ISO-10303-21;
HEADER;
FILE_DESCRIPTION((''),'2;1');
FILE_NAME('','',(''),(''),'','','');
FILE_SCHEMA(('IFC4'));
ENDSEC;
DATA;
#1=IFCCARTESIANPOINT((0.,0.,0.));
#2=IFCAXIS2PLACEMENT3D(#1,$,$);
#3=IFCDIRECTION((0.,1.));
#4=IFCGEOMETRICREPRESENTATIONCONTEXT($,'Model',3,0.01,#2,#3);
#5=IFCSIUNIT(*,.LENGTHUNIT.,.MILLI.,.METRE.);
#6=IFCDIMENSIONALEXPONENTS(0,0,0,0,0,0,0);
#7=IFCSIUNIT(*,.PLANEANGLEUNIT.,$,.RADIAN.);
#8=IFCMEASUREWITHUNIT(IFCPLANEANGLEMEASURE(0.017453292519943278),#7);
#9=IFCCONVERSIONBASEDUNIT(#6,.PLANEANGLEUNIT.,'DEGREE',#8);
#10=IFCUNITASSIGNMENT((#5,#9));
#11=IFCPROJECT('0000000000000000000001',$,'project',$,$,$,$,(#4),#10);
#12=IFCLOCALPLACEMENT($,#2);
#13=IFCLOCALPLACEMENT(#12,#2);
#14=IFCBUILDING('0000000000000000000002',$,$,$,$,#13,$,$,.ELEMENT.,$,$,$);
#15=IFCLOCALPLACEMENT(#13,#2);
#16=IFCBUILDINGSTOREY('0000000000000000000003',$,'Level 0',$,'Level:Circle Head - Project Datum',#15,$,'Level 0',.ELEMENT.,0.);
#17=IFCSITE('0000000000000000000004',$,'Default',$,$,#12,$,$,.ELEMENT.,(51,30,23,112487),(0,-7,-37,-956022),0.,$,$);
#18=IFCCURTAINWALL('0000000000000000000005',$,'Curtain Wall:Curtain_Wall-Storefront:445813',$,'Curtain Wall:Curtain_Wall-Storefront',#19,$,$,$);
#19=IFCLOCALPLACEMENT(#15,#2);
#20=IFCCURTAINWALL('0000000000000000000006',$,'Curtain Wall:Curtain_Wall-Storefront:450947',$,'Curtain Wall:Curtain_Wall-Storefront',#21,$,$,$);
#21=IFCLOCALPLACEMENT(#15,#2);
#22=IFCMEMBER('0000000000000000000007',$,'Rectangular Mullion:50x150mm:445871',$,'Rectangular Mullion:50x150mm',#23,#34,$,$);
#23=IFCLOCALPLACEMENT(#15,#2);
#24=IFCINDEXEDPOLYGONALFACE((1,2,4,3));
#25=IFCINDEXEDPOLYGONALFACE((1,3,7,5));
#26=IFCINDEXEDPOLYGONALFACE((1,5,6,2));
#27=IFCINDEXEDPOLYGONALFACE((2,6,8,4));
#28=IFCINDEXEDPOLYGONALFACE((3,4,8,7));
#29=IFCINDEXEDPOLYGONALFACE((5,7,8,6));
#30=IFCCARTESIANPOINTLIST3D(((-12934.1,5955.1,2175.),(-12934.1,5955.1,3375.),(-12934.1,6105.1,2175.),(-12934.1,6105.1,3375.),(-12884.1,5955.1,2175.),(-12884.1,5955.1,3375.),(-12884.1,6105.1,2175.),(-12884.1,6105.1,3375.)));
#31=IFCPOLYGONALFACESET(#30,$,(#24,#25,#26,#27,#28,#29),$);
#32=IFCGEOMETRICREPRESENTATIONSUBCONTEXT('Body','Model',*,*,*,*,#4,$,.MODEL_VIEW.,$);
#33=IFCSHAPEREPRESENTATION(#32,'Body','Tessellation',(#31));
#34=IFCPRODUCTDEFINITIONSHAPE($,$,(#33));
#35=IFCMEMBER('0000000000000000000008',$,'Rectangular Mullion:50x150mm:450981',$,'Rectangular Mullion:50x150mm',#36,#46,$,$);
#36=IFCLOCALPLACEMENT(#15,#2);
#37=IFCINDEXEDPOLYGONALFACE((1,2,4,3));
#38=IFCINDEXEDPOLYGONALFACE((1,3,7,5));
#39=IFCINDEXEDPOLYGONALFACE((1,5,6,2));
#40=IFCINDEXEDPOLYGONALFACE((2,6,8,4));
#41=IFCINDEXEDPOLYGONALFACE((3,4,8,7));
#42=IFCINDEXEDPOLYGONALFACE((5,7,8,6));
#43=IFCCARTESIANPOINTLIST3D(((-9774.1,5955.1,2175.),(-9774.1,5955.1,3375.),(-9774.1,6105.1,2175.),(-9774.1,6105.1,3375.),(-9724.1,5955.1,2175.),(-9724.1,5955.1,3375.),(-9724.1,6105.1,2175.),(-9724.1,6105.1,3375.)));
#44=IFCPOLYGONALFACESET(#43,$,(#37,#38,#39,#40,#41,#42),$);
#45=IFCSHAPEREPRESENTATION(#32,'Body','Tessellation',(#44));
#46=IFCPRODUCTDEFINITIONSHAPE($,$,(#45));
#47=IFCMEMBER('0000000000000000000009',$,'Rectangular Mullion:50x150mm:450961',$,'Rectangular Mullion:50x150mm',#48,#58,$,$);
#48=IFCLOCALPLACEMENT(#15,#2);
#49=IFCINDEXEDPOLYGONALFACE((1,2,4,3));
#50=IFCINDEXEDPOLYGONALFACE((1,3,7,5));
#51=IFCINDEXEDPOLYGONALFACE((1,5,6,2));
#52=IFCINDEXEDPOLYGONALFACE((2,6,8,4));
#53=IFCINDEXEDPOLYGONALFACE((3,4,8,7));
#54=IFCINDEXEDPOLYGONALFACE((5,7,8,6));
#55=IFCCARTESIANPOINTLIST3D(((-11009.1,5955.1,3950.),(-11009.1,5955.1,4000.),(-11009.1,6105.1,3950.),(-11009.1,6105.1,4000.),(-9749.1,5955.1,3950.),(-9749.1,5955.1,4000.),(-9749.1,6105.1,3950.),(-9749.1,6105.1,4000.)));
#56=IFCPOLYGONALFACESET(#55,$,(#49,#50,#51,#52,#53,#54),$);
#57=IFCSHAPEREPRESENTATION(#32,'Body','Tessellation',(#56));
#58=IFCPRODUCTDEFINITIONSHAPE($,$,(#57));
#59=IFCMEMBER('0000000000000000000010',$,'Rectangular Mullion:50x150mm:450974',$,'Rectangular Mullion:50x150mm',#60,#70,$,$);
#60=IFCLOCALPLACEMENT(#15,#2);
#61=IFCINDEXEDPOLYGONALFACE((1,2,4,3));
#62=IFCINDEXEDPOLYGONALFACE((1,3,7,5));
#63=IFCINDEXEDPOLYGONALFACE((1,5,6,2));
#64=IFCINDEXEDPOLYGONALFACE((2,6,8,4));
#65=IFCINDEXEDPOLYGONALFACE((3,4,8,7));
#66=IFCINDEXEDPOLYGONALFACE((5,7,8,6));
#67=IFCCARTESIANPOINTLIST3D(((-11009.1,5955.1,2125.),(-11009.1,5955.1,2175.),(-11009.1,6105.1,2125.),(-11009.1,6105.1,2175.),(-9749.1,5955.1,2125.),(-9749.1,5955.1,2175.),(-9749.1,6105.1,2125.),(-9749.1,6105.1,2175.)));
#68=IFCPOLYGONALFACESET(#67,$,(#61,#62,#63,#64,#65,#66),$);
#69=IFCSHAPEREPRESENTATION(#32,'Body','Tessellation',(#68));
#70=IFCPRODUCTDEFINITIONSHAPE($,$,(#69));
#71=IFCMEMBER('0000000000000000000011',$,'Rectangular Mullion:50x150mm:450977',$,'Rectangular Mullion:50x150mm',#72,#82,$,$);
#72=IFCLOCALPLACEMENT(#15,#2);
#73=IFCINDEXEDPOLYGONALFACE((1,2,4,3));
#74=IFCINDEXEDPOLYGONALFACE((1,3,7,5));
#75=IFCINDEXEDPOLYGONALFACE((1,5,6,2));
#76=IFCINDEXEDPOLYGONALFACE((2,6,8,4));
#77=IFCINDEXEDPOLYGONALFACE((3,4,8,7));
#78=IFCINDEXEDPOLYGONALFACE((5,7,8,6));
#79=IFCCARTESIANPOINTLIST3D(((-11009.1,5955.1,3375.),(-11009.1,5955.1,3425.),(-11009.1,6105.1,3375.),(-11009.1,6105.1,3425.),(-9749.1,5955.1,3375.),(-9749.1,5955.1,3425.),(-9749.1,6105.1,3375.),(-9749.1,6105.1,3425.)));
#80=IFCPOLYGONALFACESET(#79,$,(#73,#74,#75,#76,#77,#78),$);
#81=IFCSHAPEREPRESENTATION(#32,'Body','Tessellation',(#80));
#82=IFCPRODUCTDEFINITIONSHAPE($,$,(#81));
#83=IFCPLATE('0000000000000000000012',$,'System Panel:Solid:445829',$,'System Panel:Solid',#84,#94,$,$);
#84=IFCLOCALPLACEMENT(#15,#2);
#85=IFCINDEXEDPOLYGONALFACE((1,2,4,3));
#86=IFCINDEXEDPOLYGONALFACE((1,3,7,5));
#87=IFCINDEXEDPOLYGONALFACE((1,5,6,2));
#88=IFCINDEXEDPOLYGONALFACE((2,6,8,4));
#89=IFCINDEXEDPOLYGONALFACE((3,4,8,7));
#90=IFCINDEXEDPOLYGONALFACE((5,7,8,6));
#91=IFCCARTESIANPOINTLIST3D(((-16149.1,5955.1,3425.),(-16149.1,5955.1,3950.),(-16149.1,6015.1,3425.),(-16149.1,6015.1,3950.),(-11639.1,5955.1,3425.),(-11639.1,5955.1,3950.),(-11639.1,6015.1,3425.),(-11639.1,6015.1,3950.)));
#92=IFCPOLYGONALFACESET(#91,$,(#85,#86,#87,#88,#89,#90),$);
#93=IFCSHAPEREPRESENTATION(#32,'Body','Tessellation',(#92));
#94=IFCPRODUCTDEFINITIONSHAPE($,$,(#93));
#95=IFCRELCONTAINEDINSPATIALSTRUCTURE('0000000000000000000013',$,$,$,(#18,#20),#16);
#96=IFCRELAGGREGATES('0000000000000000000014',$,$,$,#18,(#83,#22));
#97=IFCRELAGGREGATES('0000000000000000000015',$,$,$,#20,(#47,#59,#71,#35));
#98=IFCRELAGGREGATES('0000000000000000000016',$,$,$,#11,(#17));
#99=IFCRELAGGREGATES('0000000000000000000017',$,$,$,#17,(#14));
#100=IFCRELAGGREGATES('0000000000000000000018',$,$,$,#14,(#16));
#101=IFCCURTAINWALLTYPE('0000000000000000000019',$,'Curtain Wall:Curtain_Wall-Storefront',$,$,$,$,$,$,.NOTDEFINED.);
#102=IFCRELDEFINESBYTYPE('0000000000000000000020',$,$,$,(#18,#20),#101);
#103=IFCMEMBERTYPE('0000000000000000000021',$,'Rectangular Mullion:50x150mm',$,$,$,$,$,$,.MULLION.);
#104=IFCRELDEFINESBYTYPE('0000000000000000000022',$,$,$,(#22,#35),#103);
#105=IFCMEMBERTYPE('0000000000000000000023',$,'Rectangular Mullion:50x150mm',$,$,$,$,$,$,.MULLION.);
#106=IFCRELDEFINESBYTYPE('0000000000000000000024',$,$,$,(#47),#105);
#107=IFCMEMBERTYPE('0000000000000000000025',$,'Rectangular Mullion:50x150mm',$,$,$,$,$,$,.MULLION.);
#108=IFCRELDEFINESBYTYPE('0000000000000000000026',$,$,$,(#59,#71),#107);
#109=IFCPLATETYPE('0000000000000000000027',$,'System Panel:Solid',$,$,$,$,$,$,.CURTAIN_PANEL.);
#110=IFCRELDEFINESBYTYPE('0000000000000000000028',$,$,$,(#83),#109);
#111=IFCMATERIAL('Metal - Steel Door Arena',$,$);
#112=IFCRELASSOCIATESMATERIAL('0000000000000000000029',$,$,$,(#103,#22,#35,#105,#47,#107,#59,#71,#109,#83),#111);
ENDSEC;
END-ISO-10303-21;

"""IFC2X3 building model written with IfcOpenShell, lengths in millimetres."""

from ifc_helpers import new_model, entity, si_unit, converted_unit, direction, frame, frame_2d, origin, origin_2d_with_axis, place, context, subcontext, project, spatial, rectangle, extrude, source, transform, mapped, material, type_object, type_shapes, element, aggregate, save


model = new_model("IFC2X3")

# Units and contexts
model_context = context("Model", 3, precision=0.01, world=origin(), true_north=direction((0.0, 1.0)))
body_context = subcontext(model_context, "Body", "Model", "MODEL_VIEW")
ifc_project = project(units=[si_unit("LENGTHUNIT", "METRE", prefix="MILLI"), converted_unit("PLANEANGLEUNIT", "DEGREE", entity("IfcPlaneAngleMeasure", 0.017453292519943278), si_unit("PLANEANGLEUNIT", "RADIAN"), dimensions=[0, 0, 0, 0, 0, 0, 0])], contexts=[model_context])

# Site, building, storey
site_placement = place(None, origin())
site = spatial("IfcSite", under=ifc_project, at=site_placement, Name="Default", CompositionType="ELEMENT", RefLatitude=(51, 30, 23, 112487), RefLongitude=(0, -7, -37, -956022), RefElevation=0.0)
building_placement = place(site_placement, origin())
building = spatial("IfcBuilding", under=site, at=building_placement, CompositionType="ELEMENT")
storey_placement = place(building_placement, origin())
storey = spatial("IfcBuildingStorey", under=building, at=storey_placement, Name="Level 0", ObjectType="Level:Circle Head - Project Datum", LongName="Level 0", CompositionType="ELEMENT", Elevation=0.0)

# Curtain walls
curtain_wall_type = type_object("IfcCurtainWallType", Name="Curtain Wall:Curtain_Wall-Storefront", PredefinedType="NOTDEFINED")
curtain_wall_1_placement = place(storey_placement, origin())
curtain_wall_1 = element("IfcCurtainWall", 1, at=curtain_wall_1_placement, inside=storey, type_object=curtain_wall_type, Name="Curtain Wall:Curtain_Wall-Storefront:445813", ObjectType="Curtain Wall:Curtain_Wall-Storefront")
ifc_material_1 = material(Name="Metal - Steel Door Arena")
curtain_wall_2_placement = place(storey_placement, origin())
curtain_wall_2 = element("IfcCurtainWall", 2, at=curtain_wall_2_placement, inside=storey, type_object=curtain_wall_type, Name="Curtain Wall:Curtain_Wall-Storefront:450947", ObjectType="Curtain Wall:Curtain_Wall-Storefront")

# Members
member_type_1 = type_object("IfcMemberType", Name="Rectangular Mullion:50x150mm", PredefinedType="MULLION", material=ifc_material_1)
shared_shape_1 = source(origin(), body_context, "Body", "SweptSolid", [
    extrude(rectangle(XDim=50.0, YDim=150.0, at=origin_2d_with_axis()), frame((0.0, 0.0, -1200.0), z_axis=(0.0, 0.0, 1.0), x_axis=(-1.0, 0.0, 0.0)), (0.0, 0.0, 1.0), 1200.0),
])
type_shapes(member_type_1, [shared_shape_1])
member_1_placement = place(curtain_wall_1_placement, frame((-12909.1, 6030.1, 2175.0), z_axis=(0.0, 0.0, -1.0), x_axis=(-1.0, 0.0, 0.0)))
member_1 = element("IfcMember", 3, at=member_1_placement, type_object=member_type_1, material=ifc_material_1, Name="Rectangular Mullion:50x150mm:445871", ObjectType="Rectangular Mullion:50x150mm", context=body_context, shape_type="MappedRepresentation", body=[
    mapped(shared_shape_1, transform((0.0, 0.0, 0.0), scale=1.0)),
])
member_2_placement = place(curtain_wall_2_placement, frame((-9749.1, 6030.1, 2175.0), z_axis=(0.0, 0.0, -1.0), x_axis=(-1.0, 0.0, 0.0)))
member_2 = element("IfcMember", 4, at=member_2_placement, type_object=member_type_1, material=ifc_material_1, Name="Rectangular Mullion:50x150mm:450981", ObjectType="Rectangular Mullion:50x150mm", context=body_context, shape_type="MappedRepresentation", body=[
    mapped(shared_shape_1, transform((0.0, 0.0, 0.0), scale=1.0)),
])
member_type_2 = type_object("IfcMemberType", Name="Rectangular Mullion:50x150mm", PredefinedType="MULLION", material=ifc_material_1)
shared_shape_2 = source(origin(), body_context, "Body", "SweptSolid", [
    extrude(rectangle(XDim=50.0, YDim=150.0, at=origin_2d_with_axis()), frame((-25.0, 0.0, -1260.0), z_axis=(0.0, 0.0, 1.0), x_axis=(-1.0, 0.0, 0.0)), (0.0, 0.0, 1.0), 1260.0),
])
type_shapes(member_type_2, [shared_shape_2])
member_3_placement = place(curtain_wall_2_placement, frame((-11009.1, 6030.1, 4000.0), z_axis=(-1.0, 0.0, 0.0), x_axis=(0.0, 0.0, 1.0)))
member_3 = element("IfcMember", 5, at=member_3_placement, type_object=member_type_2, material=ifc_material_1, Name="Rectangular Mullion:50x150mm:450961", ObjectType="Rectangular Mullion:50x150mm", context=body_context, shape_type="MappedRepresentation", body=[
    mapped(shared_shape_2, transform((0.0, 0.0, 0.0), scale=1.0)),
])
member_type_3 = type_object("IfcMemberType", Name="Rectangular Mullion:50x150mm", PredefinedType="MULLION", material=ifc_material_1)
shared_shape_3 = source(origin(), body_context, "Body", "SweptSolid", [
    extrude(rectangle(XDim=50.0, YDim=150.0, at=origin_2d_with_axis()), frame((0.0, 0.0, -1260.0), z_axis=(0.0, 0.0, 1.0), x_axis=(-1.0, 0.0, 0.0)), (0.0, 0.0, 1.0), 1260.0),
])
type_shapes(member_type_3, [shared_shape_3])
member_4_placement = place(curtain_wall_2_placement, frame((-11009.1, 6030.1, 2150.0), z_axis=(-1.0, 0.0, 0.0), x_axis=(0.0, 0.0, 1.0)))
member_4 = element("IfcMember", 6, at=member_4_placement, type_object=member_type_3, material=ifc_material_1, Name="Rectangular Mullion:50x150mm:450974", ObjectType="Rectangular Mullion:50x150mm", context=body_context, shape_type="MappedRepresentation", body=[
    mapped(shared_shape_3, transform((0.0, 0.0, 0.0), scale=1.0)),
])
member_5_placement = place(curtain_wall_2_placement, frame((-11009.1, 6030.1, 3400.0), z_axis=(-1.0, 0.0, 0.0), x_axis=(0.0, 0.0, 1.0)))
member_5 = element("IfcMember", 7, at=member_5_placement, type_object=member_type_3, material=ifc_material_1, Name="Rectangular Mullion:50x150mm:450977", ObjectType="Rectangular Mullion:50x150mm", context=body_context, shape_type="MappedRepresentation", body=[
    mapped(shared_shape_3, transform((0.0, 0.0, 0.0), scale=1.0)),
])

# Plate
plate_type_1 = type_object("IfcPlateType", Name="System Panel:Solid", PredefinedType="CURTAIN_PANEL", material=ifc_material_1)
shared_shape_4 = source(origin(), body_context, "Body", "SweptSolid", [
    extrude(rectangle(XDim=525.0, YDim=4510.0, at=frame_2d((0.0, 0.0), x_axis=(1.0, 0.0))), frame((0.0, 15.0, 262.5), z_axis=(0.0, 1.0, 0.0), x_axis=(0.0, 0.0, 1.0)), (0.0, 0.0, 1.0), 60.0),
])
type_shapes(plate_type_1, [shared_shape_4])
plate_1_placement = place(curtain_wall_1_placement, frame((-13894.1, 6030.1, 3425.0), z_axis=(0.0, 0.0, 1.0), x_axis=(-1.0, 0.0, 0.0)))
plate_1 = element("IfcPlate", 8, at=plate_1_placement, type_object=plate_type_1, material=ifc_material_1, Name="System Panel:Solid:445829", ObjectType="System Panel:Solid", context=body_context, shape_type="MappedRepresentation", body=[
    mapped(shared_shape_4, transform((0.0, 0.0, 0.0), scale=1.0)),
])
aggregate(curtain_wall_1, [plate_1, member_1])
aggregate(curtain_wall_2, [member_3, member_4, member_5, member_2])

save(model, "model.ifc")
